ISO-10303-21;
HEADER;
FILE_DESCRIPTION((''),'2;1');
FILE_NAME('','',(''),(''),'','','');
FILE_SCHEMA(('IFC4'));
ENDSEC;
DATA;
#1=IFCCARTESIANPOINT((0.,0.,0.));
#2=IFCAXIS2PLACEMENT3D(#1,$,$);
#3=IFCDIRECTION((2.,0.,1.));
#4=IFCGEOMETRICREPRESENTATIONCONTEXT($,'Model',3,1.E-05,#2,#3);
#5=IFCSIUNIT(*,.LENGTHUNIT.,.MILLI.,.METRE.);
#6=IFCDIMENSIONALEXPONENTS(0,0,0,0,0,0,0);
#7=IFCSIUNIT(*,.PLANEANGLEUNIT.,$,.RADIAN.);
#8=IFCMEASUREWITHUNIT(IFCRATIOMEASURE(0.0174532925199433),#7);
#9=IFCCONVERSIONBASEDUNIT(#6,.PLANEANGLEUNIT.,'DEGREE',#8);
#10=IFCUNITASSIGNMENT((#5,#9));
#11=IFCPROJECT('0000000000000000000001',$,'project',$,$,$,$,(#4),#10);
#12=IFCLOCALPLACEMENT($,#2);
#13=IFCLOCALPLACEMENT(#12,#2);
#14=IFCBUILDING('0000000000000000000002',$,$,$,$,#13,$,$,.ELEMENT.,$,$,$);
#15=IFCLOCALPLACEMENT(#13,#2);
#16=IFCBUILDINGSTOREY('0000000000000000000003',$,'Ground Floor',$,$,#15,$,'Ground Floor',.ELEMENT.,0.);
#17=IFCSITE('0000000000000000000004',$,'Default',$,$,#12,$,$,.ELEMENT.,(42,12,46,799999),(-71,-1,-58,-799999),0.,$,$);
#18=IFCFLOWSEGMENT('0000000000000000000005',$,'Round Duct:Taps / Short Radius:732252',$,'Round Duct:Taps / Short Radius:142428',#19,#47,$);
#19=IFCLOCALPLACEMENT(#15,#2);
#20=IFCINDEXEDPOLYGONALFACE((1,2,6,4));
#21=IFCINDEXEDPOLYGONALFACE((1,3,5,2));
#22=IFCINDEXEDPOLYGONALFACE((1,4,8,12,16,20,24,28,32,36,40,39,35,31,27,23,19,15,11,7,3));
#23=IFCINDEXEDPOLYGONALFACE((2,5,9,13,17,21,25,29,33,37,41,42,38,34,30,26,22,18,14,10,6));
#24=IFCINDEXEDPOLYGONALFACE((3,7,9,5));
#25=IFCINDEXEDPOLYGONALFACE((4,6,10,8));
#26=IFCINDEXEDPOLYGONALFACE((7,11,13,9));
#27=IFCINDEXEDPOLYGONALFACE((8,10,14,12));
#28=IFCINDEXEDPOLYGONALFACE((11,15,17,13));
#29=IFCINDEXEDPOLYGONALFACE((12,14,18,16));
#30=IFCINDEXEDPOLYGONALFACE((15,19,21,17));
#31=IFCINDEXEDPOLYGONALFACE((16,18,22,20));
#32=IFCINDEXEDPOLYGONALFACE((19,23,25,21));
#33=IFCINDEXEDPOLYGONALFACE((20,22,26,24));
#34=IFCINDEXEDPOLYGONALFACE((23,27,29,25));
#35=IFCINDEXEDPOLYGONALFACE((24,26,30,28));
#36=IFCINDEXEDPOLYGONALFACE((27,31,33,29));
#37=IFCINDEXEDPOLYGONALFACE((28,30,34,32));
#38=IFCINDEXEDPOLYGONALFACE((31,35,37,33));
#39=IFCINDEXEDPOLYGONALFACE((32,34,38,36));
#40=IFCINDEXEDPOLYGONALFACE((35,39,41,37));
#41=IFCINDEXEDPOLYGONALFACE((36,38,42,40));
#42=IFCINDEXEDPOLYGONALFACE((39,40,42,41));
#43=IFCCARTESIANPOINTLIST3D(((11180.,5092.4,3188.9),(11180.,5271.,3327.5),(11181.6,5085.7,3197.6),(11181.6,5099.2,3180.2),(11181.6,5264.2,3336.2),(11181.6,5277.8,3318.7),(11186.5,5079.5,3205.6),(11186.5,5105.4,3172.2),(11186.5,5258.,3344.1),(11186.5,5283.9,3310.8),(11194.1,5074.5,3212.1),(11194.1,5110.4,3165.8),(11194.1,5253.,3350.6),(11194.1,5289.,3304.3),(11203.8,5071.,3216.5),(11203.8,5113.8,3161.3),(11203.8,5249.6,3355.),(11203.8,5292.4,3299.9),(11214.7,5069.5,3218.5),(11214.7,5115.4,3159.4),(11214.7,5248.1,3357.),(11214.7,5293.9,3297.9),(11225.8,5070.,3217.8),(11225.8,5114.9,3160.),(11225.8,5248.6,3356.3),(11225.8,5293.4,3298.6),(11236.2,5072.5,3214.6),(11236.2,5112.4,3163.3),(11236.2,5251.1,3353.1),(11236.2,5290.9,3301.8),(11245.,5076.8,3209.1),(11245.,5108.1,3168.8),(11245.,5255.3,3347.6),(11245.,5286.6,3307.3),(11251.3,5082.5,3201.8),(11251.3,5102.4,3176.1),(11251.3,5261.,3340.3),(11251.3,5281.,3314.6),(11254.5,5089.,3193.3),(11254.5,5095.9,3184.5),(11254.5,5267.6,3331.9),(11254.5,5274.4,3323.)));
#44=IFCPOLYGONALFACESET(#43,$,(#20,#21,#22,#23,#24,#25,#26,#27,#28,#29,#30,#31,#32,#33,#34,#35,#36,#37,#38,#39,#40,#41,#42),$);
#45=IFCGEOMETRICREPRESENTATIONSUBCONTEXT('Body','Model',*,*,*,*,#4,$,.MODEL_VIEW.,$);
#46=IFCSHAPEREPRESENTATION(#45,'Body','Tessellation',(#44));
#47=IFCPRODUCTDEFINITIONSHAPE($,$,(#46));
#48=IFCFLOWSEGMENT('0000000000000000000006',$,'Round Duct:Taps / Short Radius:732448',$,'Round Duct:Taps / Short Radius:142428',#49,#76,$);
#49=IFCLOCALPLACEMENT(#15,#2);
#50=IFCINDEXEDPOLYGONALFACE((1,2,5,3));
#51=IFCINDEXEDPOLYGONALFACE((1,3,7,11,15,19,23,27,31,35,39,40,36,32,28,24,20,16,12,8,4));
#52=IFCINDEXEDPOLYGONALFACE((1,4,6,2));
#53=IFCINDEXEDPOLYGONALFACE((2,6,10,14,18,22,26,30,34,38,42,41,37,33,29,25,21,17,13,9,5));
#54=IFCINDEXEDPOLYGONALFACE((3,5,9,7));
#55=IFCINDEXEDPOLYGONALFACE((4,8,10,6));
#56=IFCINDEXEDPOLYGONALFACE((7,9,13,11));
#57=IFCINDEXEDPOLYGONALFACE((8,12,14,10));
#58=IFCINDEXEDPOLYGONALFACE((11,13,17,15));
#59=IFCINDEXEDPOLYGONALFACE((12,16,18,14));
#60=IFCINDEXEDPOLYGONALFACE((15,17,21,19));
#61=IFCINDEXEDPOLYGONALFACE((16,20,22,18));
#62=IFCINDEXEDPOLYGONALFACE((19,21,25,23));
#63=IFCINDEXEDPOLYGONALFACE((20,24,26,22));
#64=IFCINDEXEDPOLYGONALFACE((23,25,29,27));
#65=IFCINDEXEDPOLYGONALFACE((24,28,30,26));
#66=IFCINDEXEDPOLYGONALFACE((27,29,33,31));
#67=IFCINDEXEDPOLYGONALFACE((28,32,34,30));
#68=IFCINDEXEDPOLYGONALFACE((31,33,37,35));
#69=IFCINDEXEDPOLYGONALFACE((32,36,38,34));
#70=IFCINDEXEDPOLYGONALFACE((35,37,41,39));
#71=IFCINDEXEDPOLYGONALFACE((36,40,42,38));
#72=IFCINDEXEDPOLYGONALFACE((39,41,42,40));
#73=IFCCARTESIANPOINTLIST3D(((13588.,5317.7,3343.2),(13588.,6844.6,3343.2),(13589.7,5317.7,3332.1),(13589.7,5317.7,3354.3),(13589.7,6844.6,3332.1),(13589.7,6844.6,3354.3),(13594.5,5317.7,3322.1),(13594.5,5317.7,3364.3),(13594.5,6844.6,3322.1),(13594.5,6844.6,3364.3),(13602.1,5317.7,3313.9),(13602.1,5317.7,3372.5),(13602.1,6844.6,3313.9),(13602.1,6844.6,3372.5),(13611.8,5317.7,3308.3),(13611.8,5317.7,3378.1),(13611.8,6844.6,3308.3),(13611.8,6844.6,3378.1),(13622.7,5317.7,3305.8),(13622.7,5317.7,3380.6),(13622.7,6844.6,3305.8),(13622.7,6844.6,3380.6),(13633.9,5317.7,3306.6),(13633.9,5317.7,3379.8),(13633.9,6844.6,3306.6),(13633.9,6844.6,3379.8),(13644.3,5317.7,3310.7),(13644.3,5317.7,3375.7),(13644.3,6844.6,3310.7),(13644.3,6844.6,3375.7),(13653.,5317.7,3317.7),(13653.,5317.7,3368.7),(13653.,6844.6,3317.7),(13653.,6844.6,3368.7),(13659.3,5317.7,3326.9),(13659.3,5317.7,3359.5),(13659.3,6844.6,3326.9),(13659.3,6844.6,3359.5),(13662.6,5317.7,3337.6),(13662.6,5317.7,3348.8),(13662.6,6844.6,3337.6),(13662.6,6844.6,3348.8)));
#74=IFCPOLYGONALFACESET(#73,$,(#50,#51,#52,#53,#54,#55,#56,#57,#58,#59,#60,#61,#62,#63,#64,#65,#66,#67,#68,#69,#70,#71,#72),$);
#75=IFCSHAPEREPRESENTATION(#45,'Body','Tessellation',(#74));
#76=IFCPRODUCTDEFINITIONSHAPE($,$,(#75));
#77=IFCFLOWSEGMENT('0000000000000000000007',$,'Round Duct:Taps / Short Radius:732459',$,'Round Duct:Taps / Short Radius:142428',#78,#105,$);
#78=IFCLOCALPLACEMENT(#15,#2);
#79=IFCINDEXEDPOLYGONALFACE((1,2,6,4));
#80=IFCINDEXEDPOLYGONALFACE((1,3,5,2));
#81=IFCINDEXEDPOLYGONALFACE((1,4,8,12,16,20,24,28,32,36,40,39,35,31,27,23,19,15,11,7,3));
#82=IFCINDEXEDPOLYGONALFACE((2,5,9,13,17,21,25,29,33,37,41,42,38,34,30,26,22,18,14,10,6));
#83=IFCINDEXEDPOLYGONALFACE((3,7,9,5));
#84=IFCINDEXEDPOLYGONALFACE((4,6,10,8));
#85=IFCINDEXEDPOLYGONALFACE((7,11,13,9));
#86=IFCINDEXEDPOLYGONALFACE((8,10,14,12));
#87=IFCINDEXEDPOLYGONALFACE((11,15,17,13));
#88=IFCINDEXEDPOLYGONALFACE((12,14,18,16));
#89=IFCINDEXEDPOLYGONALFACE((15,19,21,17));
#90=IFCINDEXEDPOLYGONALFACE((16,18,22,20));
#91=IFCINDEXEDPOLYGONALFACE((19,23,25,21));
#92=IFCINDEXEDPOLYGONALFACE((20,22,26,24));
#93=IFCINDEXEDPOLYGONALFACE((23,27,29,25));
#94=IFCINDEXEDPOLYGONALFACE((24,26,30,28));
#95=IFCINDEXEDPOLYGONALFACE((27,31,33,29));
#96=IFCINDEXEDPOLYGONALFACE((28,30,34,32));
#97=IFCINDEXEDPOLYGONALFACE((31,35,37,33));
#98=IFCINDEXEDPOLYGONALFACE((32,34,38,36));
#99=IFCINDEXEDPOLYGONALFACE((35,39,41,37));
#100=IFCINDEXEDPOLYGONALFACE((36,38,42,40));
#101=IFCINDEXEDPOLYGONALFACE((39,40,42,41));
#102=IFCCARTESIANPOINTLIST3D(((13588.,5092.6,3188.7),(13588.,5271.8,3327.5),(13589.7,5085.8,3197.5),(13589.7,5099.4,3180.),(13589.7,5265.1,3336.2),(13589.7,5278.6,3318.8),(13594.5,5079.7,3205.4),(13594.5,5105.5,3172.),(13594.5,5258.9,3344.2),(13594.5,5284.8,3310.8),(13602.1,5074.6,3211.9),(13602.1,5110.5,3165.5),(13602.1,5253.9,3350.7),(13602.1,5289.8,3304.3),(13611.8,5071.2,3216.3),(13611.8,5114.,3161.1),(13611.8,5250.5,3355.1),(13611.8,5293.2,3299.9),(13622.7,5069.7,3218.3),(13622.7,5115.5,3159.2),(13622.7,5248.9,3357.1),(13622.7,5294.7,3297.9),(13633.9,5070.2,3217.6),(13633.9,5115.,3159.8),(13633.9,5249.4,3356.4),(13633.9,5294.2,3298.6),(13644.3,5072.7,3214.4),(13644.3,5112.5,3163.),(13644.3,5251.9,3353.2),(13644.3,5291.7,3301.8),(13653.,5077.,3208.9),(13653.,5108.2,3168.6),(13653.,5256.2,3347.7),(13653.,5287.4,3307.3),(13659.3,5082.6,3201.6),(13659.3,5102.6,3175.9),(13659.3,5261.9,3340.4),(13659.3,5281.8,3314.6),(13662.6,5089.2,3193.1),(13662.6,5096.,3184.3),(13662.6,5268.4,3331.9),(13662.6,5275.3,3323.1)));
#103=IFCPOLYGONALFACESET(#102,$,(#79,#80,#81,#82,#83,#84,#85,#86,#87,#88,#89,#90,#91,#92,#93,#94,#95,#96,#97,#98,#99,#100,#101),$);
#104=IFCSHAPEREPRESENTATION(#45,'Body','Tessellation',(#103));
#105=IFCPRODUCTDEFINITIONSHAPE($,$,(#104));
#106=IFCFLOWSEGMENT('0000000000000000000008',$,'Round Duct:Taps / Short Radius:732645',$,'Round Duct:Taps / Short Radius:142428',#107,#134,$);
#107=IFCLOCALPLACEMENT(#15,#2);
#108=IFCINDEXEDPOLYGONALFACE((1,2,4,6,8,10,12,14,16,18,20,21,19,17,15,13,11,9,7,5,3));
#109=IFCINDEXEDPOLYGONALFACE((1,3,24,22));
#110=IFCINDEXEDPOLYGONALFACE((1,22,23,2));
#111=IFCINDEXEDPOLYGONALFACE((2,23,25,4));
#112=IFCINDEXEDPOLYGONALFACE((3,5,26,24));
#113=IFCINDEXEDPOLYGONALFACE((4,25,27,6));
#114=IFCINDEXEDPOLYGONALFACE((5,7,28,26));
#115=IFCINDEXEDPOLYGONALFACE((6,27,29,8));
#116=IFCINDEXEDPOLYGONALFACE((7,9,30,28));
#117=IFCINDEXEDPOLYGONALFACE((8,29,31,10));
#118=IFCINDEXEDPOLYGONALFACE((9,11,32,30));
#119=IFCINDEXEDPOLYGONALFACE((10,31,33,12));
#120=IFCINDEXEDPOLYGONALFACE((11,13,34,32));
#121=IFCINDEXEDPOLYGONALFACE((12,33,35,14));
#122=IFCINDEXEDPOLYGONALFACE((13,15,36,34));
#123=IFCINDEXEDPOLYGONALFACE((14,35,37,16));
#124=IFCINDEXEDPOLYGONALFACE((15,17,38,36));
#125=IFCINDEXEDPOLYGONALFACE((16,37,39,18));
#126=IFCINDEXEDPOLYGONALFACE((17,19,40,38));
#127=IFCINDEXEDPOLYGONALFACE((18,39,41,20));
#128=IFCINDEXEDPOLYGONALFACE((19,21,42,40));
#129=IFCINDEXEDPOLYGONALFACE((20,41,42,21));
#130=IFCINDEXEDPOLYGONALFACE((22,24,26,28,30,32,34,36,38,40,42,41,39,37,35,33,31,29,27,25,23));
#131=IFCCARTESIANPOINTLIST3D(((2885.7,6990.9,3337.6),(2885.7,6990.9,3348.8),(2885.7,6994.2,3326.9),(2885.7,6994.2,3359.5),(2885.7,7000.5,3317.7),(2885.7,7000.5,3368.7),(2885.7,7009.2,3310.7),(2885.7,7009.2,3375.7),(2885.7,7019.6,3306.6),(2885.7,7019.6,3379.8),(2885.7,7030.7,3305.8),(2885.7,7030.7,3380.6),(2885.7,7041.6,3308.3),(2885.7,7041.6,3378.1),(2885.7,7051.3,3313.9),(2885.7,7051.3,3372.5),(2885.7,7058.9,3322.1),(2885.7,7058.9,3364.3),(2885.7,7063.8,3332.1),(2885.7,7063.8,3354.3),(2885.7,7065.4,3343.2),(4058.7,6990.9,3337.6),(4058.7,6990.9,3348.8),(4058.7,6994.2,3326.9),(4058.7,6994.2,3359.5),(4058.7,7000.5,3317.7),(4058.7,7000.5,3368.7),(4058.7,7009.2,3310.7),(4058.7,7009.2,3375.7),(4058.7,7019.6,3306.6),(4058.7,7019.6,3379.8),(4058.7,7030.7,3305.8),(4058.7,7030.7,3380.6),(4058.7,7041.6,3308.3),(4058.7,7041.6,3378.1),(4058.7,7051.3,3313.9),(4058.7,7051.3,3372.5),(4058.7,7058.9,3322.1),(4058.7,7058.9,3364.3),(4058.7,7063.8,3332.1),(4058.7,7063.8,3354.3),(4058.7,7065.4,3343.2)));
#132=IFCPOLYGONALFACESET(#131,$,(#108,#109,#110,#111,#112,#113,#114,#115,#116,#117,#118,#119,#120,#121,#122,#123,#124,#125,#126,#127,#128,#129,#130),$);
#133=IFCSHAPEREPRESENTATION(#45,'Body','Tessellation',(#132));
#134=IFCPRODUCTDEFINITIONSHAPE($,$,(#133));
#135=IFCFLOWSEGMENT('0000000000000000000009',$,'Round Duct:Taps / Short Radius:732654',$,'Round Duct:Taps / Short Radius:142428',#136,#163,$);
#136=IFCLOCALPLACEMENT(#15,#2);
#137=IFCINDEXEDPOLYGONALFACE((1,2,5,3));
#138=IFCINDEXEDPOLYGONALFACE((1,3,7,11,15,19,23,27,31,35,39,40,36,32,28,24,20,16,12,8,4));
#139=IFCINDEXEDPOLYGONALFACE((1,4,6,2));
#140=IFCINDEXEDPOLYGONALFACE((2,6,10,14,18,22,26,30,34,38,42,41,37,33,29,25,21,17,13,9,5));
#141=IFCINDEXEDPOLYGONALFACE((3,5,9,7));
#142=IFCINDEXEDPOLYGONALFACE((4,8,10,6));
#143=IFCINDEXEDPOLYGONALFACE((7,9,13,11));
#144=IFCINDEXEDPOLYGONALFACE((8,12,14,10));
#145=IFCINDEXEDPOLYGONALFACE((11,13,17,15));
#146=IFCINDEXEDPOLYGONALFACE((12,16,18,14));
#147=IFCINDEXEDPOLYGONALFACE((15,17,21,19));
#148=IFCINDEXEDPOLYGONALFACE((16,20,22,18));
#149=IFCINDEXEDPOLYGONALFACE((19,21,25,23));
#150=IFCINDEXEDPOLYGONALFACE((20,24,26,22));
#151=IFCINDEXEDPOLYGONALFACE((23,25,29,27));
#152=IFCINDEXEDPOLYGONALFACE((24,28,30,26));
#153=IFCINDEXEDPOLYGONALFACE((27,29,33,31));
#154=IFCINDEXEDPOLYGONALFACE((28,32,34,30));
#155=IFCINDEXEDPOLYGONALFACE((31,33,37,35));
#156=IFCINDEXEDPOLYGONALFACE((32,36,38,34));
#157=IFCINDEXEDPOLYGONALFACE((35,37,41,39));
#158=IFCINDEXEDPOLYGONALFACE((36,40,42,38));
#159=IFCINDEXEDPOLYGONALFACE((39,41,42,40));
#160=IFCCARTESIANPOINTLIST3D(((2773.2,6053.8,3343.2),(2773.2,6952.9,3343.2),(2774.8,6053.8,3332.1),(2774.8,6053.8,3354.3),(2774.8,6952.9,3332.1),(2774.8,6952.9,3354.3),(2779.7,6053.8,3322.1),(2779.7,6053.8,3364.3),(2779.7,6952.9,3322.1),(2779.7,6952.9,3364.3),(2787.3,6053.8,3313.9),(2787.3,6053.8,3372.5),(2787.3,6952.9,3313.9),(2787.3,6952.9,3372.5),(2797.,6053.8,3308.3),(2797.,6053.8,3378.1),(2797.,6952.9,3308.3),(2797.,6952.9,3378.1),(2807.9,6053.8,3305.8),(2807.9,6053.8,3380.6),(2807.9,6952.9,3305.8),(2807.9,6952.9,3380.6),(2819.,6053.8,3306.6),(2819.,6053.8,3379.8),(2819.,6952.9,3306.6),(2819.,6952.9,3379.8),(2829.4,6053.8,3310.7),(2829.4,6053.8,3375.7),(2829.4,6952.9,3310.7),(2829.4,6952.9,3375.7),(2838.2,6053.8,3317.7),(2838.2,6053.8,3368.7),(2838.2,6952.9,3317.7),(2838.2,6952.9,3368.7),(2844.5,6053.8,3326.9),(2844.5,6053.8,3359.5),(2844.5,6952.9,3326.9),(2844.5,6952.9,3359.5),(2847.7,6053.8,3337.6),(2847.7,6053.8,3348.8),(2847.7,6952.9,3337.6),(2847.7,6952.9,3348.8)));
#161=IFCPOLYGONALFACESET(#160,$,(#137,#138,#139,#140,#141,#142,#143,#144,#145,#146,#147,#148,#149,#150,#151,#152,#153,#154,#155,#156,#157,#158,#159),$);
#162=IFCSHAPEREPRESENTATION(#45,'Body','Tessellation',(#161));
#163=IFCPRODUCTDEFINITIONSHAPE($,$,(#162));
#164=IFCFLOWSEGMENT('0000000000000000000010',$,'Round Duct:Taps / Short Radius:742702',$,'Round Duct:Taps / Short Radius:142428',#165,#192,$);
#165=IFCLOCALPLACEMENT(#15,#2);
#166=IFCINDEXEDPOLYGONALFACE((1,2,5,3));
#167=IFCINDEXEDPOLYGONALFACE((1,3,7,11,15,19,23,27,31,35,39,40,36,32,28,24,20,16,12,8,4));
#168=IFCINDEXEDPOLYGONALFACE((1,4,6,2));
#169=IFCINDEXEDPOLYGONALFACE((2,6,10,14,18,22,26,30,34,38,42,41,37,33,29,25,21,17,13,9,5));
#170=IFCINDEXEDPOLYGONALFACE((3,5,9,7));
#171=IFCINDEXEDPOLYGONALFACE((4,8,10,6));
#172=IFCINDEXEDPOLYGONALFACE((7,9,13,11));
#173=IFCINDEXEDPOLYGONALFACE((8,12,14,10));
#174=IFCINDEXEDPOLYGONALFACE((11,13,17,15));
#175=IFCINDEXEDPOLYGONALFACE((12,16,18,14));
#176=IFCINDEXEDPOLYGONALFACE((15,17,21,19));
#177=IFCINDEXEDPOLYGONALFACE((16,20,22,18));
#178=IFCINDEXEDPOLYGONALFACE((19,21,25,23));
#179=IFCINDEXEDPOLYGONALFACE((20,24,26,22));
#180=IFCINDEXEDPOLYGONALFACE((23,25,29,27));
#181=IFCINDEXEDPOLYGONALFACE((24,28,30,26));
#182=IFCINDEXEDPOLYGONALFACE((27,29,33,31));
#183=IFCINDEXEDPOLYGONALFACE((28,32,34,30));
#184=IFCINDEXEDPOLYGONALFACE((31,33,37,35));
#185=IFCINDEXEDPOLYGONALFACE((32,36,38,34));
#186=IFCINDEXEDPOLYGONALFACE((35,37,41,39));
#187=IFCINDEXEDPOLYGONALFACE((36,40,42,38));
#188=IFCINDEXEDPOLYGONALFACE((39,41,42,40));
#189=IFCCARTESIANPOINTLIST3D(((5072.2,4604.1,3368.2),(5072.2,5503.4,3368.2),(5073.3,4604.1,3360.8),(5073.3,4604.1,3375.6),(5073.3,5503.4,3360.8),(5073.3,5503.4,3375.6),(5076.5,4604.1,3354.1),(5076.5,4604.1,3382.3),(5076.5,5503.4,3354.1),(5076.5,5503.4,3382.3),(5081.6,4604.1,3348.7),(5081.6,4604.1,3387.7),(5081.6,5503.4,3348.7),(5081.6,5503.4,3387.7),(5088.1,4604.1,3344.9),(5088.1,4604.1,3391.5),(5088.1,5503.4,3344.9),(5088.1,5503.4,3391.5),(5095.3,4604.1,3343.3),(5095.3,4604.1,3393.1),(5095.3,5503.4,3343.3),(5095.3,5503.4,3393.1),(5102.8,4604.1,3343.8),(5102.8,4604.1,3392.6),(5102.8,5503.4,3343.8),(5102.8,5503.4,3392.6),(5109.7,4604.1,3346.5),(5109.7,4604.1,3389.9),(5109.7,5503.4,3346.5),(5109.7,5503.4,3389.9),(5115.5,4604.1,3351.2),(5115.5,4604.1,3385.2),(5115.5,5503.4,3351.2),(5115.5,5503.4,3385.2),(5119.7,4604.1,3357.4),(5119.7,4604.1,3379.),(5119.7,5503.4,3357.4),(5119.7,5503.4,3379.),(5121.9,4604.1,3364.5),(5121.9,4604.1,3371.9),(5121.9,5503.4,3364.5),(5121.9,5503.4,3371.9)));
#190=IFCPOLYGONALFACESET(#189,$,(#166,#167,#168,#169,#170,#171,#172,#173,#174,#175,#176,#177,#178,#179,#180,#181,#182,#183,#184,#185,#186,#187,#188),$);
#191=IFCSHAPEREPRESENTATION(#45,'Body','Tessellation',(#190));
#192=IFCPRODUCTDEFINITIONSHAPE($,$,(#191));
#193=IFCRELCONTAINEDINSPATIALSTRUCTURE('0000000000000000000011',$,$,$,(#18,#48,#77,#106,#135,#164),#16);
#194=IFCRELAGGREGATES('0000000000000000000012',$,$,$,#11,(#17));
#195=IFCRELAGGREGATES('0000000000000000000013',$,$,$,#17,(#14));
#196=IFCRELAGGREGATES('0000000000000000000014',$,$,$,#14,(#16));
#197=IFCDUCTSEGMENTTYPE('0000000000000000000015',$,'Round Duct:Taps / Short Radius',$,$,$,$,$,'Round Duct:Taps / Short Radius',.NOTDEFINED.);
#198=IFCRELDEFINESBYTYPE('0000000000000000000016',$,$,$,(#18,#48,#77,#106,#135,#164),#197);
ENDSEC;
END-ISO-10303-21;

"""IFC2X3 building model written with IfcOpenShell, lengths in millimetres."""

from ifc_helpers import new_model, entity, si_unit, converted_unit, direction, frame, frame_2d, origin, place, context, subcontext, project, spatial, circle, extrude, type_object, element, save


model = new_model("IFC2X3")

# Units and contexts
model_context = context("Model", 3, precision=1e-05, world=origin(), true_north=direction((2.0, 0.0, 1.0)))
body_context = subcontext(model_context, "Body", "Model", "MODEL_VIEW")
ifc_project = project(units=[si_unit("LENGTHUNIT", "METRE", prefix="MILLI"), converted_unit("PLANEANGLEUNIT", "DEGREE", entity("IfcRatioMeasure", 0.0174532925199433), si_unit("PLANEANGLEUNIT", "RADIAN"), dimensions=[0, 0, 0, 0, 0, 0, 0])], contexts=[model_context])

# Site, building, storey
site_placement = place(None, origin())
site = spatial("IfcSite", under=ifc_project, at=site_placement, Name="Default", CompositionType="ELEMENT", RefLatitude=(42, 12, 46, 799999), RefLongitude=(-71, -1, -58, -799999), RefElevation=0.0)
building_placement = place(site_placement, origin())
building = spatial("IfcBuilding", under=site, at=building_placement, CompositionType="ELEMENT")
storey_placement = place(building_placement, origin())
storey = spatial("IfcBuildingStorey", under=building, at=storey_placement, Name="Ground Floor", LongName="Ground Floor", CompositionType="ELEMENT", Elevation=0.0)

# Flow segments
duct_segment_type_1 = type_object("IfcDuctSegmentType", Name="Round Duct:Taps / Short Radius", ElementType="Round Duct:Taps / Short Radius", PredefinedType="NOTDEFINED")
flow_segment_1_placement = place(storey_placement, origin())
element("IfcFlowSegment", 1, at=flow_segment_1_placement, inside=storey, type_object=duct_segment_type_1, Name="Round Duct:Taps / Short Radius:732252", ObjectType="Round Duct:Taps / Short Radius:142428", context=body_context, shape_type="SweptSolid", body=[
    extrude(circle(Radius=37.5, at=frame_2d((0.0, 0.0), x_axis=(1.0, 0.0))), frame((11217.5, 5092.4, 3188.9), z_axis=(0.0, 0.790046, 0.613047), x_axis=(-1.0, 0.0, 0.0)), (0.0, 0.0, 1.0), 226.0),
])
flow_segment_2_placement = place(storey_placement, origin())
element("IfcFlowSegment", 2, at=flow_segment_2_placement, inside=storey, type_object=duct_segment_type_1, Name="Round Duct:Taps / Short Radius:732448", ObjectType="Round Duct:Taps / Short Radius:142428", context=body_context, shape_type="SweptSolid", body=[
    extrude(circle(Radius=37.5, at=frame_2d((0.0, 0.0), x_axis=(1.0, 0.0))), frame((13625.5, 5317.7, 3343.2), z_axis=(0.0, 1.0, 0.0), x_axis=(-1.0, 0.0, 0.0)), (0.0, 0.0, 1.0), 1526.9),
])
flow_segment_3_placement = place(storey_placement, origin())
element("IfcFlowSegment", 3, at=flow_segment_3_placement, inside=storey, type_object=duct_segment_type_1, Name="Round Duct:Taps / Short Radius:732459", ObjectType="Round Duct:Taps / Short Radius:142428", context=body_context, shape_type="SweptSolid", body=[
    extrude(circle(Radius=37.5, at=frame_2d((0.0, 0.0), x_axis=(1.0, 0.0))), frame((13625.5, 5092.6, 3188.7), z_axis=(0.0, 0.790697, 0.612207), x_axis=(-1.0, 0.0, 0.0)), (0.0, 0.0, 1.0), 226.7),
])
flow_segment_4_placement = place(storey_placement, origin())
element("IfcFlowSegment", 4, at=flow_segment_4_placement, inside=storey, type_object=duct_segment_type_1, Name="Round Duct:Taps / Short Radius:732645", ObjectType="Round Duct:Taps / Short Radius:142428", context=body_context, shape_type="SweptSolid", body=[
    extrude(circle(Radius=37.5, at=frame_2d((0.0, 0.0), x_axis=(1.0, 0.0))), frame((2885.7, 7027.9, 3343.2), z_axis=(1.0, 0.0, 0.0), x_axis=(0.0, 1.0, 0.0)), (0.0, 0.0, 1.0), 1173.0),
])
flow_segment_5_placement = place(storey_placement, origin())
element("IfcFlowSegment", 5, at=flow_segment_5_placement, inside=storey, type_object=duct_segment_type_1, Name="Round Duct:Taps / Short Radius:732654", ObjectType="Round Duct:Taps / Short Radius:142428", context=body_context, shape_type="SweptSolid", body=[
    extrude(circle(Radius=37.5, at=frame_2d((0.0, 0.0), x_axis=(1.0, 0.0))), frame((2810.7, 6053.8, 3343.2), z_axis=(0.0, 1.0, 0.0), x_axis=(-1.0, 0.0, 0.0)), (0.0, 0.0, 1.0), 899.2),
])
flow_segment_6_placement = place(storey_placement, origin())
element("IfcFlowSegment", 6, at=flow_segment_6_placement, inside=storey, type_object=duct_segment_type_1, Name="Round Duct:Taps / Short Radius:742702", ObjectType="Round Duct:Taps / Short Radius:142428", context=body_context, shape_type="SweptSolid", body=[
    extrude(circle(Radius=25.0, at=frame_2d((0.0, 0.0), x_axis=(1.0, 0.0))), frame((5097.2, 4604.1, 3368.2), z_axis=(0.0, 1.0, 0.0), x_axis=(-1.0, 0.0, 0.0)), (0.0, 0.0, 1.0), 899.4),
])

save(model, "model.ifc")
